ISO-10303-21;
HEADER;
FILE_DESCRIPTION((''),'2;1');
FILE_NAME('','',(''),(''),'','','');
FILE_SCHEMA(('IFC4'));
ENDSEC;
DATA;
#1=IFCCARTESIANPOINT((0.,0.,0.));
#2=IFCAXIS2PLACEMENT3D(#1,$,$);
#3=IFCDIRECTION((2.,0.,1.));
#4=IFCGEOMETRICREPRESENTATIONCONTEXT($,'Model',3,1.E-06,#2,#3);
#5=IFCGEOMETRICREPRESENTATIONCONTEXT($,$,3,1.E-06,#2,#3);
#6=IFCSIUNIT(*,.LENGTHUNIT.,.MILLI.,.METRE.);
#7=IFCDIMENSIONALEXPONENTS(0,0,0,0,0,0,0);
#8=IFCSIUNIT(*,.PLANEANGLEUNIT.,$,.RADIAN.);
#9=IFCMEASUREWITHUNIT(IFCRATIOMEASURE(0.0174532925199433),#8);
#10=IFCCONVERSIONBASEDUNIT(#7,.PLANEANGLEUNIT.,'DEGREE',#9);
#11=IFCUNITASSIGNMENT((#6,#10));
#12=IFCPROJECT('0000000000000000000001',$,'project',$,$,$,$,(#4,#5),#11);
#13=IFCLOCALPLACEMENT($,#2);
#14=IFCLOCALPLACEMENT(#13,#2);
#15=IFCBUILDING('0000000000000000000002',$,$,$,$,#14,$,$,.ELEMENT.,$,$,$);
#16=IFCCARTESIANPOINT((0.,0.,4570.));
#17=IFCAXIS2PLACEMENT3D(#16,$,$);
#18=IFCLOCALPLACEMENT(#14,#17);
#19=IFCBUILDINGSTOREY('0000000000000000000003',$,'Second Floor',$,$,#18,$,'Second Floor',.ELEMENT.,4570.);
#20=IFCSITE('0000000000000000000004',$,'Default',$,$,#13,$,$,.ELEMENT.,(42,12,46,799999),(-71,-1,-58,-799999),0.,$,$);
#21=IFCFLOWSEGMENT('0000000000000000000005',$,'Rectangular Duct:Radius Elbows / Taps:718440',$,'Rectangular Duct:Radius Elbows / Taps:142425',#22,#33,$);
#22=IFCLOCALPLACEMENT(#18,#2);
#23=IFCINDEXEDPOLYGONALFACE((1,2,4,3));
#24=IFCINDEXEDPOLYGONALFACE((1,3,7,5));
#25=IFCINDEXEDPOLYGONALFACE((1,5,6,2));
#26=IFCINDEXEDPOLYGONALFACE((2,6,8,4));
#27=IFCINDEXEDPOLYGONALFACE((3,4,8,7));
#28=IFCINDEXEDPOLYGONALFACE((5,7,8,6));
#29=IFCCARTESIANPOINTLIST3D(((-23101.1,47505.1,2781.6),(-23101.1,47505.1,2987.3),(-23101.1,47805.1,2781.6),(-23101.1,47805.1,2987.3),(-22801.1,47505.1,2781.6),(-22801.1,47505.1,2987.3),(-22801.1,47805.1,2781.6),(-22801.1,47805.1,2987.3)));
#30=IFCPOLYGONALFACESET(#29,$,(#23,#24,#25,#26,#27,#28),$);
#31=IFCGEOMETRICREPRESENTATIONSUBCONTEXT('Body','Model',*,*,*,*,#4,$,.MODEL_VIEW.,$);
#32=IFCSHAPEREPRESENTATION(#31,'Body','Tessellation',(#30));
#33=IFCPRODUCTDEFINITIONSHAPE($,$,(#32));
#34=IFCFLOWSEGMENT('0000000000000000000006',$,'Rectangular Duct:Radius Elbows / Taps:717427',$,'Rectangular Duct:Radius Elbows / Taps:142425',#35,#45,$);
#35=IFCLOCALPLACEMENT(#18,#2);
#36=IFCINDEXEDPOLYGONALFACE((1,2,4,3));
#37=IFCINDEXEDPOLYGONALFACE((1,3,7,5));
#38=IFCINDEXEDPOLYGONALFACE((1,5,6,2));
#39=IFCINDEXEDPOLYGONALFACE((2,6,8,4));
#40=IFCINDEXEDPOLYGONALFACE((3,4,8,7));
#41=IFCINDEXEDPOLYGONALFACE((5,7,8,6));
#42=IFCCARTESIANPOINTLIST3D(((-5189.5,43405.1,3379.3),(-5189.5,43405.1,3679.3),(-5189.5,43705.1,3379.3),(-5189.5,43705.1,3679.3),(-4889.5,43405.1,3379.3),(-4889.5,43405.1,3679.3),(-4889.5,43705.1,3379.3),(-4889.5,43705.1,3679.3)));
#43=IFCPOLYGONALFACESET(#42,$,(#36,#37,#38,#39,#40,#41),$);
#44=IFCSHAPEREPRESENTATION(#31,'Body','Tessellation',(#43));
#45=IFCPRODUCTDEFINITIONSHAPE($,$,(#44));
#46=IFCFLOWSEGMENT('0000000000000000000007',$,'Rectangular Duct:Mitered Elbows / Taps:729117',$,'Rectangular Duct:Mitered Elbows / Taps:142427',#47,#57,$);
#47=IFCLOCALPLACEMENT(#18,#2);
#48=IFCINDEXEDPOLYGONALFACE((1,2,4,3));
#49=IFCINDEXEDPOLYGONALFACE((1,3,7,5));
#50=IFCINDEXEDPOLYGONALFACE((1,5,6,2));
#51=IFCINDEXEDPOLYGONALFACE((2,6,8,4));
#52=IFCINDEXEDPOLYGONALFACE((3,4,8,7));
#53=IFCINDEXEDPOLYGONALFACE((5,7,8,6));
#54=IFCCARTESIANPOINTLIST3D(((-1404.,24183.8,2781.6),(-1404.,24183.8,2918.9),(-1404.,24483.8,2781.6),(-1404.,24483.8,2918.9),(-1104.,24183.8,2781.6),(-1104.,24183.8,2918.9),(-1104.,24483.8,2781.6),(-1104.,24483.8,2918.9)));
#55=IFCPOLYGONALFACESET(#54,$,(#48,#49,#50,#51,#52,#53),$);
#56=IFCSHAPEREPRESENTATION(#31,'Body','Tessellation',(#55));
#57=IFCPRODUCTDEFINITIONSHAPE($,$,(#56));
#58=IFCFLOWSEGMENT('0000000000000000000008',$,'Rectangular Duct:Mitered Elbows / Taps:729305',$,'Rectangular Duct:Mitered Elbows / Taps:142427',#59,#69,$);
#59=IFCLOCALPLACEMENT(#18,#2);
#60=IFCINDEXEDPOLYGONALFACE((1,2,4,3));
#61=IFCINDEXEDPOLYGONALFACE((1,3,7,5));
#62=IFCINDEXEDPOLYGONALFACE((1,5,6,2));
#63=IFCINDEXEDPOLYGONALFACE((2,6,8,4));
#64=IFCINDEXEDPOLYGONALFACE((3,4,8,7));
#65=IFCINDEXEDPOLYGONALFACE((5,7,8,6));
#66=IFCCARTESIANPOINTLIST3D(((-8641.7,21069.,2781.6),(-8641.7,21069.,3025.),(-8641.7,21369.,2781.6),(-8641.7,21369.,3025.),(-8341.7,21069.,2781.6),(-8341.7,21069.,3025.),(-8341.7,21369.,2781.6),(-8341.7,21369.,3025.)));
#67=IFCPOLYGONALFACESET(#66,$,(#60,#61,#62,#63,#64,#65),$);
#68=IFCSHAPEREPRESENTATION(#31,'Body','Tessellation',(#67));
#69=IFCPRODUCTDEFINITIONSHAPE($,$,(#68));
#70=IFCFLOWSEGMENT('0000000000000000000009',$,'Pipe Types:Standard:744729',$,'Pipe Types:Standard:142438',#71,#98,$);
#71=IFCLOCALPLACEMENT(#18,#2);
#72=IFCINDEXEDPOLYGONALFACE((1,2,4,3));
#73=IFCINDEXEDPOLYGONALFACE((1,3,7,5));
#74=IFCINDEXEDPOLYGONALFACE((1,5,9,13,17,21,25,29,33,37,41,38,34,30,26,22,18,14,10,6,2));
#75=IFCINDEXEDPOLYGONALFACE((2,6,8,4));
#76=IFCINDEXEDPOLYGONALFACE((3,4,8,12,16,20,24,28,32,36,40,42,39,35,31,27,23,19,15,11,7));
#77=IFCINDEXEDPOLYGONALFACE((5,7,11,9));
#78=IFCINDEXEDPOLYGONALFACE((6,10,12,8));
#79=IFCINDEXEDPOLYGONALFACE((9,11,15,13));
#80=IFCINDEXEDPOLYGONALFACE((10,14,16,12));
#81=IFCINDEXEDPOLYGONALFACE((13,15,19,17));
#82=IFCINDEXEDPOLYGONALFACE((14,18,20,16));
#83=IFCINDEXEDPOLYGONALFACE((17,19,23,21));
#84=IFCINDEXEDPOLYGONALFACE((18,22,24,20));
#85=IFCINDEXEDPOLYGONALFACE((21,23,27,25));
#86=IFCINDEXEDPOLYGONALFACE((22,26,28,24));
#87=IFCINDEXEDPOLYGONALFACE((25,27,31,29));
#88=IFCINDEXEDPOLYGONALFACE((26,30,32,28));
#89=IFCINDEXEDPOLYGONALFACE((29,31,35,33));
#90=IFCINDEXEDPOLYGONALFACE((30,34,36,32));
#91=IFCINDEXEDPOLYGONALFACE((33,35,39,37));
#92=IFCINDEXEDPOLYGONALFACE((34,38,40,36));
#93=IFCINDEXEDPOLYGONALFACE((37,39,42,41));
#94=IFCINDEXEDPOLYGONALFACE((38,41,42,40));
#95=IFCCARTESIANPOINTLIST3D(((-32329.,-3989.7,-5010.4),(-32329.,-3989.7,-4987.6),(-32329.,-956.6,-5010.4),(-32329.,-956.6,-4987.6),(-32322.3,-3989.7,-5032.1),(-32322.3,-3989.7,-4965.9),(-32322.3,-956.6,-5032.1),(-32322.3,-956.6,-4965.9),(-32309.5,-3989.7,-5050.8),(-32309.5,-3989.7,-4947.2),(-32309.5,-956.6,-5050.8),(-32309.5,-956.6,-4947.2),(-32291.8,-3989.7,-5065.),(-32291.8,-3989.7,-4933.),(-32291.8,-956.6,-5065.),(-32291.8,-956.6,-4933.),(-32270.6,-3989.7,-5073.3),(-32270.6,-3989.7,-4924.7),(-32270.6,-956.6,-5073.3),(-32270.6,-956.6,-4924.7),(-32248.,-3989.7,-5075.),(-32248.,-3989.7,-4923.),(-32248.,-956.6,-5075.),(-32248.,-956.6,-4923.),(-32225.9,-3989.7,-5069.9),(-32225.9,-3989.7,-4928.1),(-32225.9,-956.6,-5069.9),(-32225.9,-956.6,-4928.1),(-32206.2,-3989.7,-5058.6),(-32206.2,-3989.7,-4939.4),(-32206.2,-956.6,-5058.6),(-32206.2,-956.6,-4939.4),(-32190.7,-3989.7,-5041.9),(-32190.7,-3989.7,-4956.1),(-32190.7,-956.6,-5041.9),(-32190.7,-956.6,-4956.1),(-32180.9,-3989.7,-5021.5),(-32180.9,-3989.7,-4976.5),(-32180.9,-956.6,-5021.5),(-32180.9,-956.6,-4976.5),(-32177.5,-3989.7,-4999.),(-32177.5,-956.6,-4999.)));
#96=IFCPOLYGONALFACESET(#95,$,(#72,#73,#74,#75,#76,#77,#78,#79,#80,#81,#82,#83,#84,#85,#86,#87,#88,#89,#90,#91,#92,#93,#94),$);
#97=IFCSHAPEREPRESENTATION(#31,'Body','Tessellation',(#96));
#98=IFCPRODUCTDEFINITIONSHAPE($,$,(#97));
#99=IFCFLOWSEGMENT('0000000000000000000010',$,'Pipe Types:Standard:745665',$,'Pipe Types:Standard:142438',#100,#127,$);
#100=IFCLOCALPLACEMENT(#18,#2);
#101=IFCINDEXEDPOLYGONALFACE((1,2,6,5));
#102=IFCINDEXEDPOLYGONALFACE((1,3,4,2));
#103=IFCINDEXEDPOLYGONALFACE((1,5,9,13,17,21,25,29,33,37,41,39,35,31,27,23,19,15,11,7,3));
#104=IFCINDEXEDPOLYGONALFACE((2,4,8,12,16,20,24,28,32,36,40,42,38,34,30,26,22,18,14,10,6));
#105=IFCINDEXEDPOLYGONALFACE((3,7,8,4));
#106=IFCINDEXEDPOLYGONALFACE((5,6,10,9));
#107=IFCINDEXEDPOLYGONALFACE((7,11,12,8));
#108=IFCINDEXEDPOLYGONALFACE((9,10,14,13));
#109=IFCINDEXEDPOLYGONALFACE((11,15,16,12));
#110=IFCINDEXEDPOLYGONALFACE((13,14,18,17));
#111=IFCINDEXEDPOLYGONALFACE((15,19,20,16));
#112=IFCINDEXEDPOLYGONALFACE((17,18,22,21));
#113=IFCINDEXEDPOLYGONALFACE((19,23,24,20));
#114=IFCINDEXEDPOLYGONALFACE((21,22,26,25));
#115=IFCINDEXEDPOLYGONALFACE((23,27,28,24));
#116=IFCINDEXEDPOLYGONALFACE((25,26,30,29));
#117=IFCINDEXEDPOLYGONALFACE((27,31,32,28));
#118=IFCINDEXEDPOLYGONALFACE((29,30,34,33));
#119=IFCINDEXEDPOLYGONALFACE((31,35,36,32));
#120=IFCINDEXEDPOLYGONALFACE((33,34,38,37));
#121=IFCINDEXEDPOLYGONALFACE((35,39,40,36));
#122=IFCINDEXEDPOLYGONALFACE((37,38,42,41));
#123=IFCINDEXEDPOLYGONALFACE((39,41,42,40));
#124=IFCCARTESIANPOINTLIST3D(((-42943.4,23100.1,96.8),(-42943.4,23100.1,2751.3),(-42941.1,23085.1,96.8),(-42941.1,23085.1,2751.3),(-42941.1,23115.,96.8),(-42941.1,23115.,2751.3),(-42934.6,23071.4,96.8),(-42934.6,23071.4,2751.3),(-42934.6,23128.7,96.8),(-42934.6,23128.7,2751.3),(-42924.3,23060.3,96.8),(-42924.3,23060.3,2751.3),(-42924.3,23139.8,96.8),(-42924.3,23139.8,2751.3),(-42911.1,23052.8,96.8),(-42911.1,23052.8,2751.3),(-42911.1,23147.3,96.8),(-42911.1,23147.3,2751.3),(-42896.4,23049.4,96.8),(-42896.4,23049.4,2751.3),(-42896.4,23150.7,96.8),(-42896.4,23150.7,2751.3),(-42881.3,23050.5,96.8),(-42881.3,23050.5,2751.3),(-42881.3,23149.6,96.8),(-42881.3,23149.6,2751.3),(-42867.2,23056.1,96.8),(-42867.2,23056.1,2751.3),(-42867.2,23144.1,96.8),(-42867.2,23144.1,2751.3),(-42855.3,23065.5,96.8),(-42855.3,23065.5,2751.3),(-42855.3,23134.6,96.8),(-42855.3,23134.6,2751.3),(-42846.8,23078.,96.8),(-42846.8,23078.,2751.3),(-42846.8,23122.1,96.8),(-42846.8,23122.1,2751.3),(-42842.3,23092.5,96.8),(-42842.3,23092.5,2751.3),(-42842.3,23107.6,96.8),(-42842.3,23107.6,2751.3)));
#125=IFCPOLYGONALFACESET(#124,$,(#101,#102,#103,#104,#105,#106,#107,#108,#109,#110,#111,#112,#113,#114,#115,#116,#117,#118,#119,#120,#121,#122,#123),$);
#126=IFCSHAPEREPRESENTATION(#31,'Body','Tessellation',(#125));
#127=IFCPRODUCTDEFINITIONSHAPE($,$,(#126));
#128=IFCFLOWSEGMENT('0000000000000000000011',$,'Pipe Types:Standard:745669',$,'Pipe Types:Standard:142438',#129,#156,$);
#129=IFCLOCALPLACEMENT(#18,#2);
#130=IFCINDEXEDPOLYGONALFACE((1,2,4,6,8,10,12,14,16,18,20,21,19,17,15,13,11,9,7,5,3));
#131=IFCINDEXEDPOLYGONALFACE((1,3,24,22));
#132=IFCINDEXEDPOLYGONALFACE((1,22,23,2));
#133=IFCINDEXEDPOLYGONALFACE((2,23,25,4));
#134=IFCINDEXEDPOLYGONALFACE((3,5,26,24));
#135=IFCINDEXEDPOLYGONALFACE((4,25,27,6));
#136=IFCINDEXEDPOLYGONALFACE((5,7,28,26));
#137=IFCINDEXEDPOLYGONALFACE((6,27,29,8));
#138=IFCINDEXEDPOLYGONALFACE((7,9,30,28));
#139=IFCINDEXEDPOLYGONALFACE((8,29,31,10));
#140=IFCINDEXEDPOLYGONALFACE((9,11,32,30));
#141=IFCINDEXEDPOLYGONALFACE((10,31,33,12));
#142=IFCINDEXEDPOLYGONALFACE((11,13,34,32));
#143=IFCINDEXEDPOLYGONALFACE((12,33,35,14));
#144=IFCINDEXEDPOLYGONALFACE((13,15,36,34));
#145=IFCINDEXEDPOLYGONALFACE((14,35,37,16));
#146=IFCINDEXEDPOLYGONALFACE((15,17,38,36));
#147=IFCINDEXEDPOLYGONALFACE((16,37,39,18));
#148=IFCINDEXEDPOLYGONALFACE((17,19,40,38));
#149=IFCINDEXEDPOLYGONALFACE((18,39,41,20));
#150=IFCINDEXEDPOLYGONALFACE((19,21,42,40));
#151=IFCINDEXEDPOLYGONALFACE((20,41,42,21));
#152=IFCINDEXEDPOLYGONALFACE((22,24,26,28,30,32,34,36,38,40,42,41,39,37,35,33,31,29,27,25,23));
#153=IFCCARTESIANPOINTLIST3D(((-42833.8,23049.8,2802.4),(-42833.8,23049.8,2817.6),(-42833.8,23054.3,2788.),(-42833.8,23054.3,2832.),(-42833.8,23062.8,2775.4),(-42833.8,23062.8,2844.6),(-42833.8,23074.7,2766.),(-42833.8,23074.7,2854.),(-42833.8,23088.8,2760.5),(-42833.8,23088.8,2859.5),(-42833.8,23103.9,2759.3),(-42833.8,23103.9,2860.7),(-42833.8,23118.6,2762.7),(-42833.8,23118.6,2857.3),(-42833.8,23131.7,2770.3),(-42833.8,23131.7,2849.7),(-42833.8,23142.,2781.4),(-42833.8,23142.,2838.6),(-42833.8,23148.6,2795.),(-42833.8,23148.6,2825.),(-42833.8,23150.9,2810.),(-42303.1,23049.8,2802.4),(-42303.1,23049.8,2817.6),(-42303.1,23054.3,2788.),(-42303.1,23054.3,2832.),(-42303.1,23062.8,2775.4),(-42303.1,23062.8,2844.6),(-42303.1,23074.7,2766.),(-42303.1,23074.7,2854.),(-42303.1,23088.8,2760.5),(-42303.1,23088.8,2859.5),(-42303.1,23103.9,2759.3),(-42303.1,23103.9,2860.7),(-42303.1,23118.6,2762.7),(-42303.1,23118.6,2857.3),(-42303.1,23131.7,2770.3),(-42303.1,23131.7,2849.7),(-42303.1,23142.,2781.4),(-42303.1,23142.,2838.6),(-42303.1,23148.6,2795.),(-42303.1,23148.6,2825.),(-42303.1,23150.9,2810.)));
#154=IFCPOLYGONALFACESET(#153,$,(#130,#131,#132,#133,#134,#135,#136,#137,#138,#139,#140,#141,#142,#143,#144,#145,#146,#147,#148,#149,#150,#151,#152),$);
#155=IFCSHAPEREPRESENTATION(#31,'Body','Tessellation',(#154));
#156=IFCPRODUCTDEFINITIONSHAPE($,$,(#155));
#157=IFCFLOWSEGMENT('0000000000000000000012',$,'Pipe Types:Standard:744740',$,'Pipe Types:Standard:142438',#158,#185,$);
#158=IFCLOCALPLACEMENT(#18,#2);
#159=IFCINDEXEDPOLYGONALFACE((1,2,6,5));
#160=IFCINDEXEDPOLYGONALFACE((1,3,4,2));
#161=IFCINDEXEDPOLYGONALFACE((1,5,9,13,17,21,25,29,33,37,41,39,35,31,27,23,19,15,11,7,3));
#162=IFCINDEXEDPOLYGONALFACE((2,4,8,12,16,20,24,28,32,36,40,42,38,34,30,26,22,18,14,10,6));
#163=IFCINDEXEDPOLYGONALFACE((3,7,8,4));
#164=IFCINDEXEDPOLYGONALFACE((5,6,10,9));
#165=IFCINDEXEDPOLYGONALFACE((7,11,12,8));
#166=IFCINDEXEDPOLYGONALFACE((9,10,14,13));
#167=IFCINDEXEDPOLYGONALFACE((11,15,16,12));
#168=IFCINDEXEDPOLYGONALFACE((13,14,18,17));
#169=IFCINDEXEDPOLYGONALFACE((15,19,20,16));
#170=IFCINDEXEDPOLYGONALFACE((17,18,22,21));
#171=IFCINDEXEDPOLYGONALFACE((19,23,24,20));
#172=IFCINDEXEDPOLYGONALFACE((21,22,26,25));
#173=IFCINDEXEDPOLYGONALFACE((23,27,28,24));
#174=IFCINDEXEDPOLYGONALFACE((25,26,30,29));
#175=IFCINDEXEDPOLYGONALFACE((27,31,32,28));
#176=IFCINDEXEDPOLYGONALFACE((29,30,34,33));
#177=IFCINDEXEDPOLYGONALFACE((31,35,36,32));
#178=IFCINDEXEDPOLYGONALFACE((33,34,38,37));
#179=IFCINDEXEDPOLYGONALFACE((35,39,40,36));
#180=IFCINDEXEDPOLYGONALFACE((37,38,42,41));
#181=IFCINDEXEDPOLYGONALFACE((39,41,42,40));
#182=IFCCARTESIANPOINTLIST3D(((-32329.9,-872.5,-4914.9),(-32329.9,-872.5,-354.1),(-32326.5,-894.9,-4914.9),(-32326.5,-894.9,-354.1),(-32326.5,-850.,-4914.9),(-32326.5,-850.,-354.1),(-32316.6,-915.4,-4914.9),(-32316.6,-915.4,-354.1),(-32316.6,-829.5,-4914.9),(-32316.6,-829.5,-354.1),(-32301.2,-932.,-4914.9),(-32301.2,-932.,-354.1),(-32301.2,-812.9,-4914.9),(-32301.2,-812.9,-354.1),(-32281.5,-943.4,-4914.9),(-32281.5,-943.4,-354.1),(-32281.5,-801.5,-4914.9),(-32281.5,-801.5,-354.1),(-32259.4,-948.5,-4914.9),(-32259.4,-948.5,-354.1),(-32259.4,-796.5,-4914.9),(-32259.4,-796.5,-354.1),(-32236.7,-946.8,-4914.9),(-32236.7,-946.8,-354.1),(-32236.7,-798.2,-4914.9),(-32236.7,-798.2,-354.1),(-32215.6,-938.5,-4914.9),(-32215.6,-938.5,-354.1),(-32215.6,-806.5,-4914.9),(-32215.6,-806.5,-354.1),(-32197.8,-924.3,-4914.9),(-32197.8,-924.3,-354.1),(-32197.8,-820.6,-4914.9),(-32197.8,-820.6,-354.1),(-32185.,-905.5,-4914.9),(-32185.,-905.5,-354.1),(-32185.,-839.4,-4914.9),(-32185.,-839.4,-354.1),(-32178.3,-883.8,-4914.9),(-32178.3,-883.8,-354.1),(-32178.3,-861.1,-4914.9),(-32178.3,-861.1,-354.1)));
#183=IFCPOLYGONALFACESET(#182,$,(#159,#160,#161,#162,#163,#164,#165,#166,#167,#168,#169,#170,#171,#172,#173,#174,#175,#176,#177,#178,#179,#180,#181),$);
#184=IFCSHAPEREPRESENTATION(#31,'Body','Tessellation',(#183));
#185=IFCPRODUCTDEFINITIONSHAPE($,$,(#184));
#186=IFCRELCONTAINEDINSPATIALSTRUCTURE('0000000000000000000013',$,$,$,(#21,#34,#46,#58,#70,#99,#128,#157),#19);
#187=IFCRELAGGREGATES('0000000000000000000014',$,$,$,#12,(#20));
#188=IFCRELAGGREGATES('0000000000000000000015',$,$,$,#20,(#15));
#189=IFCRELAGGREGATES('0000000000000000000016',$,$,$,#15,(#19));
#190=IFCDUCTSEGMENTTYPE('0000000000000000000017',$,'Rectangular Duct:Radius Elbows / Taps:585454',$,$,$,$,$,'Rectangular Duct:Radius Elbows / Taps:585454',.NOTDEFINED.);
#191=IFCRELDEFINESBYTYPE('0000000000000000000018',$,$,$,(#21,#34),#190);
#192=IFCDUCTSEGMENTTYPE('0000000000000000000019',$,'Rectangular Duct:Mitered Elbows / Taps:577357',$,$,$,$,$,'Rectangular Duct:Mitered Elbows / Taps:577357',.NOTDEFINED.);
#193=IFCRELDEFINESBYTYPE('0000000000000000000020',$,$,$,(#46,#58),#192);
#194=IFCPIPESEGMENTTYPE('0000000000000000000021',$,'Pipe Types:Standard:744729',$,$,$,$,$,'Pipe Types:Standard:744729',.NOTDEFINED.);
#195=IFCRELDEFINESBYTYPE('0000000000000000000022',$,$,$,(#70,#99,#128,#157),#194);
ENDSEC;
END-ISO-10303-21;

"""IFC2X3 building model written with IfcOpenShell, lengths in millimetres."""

from ifc_helpers import new_model, entity, si_unit, converted_unit, direction, frame, frame_2d, origin, origin_2d_with_axis, place, context, subcontext, project, spatial, rectangle, circle, extrude, type_object, element, save


model = new_model("IFC2X3")

# Units and contexts
model_context = context("Model", 3, precision=1e-06, world=origin(), true_north=direction((2.0, 0.0, 1.0)))
context_of_model = context(None, 3, precision=1e-06, world=origin(), true_north=direction((2.0, 0.0, 1.0)))
body_context = subcontext(model_context, "Body", "Model", "MODEL_VIEW")
ifc_project = project(units=[si_unit("LENGTHUNIT", "METRE", prefix="MILLI"), converted_unit("PLANEANGLEUNIT", "DEGREE", entity("IfcRatioMeasure", 0.0174532925199433), si_unit("PLANEANGLEUNIT", "RADIAN"), dimensions=[0, 0, 0, 0, 0, 0, 0])], contexts=[model_context, context_of_model])

# Site, building, storey
site_placement = place(None, origin())
site = spatial("IfcSite", under=ifc_project, at=site_placement, Name="Default", CompositionType="ELEMENT", RefLatitude=(42, 12, 46, 799999), RefLongitude=(-71, -1, -58, -799999), RefElevation=0.0)
building_placement = place(site_placement, origin())
building = spatial("IfcBuilding", under=site, at=building_placement, CompositionType="ELEMENT")
storey_placement = place(building_placement, frame((0.0, 0.0, 4570.0)))
storey = spatial("IfcBuildingStorey", under=building, at=storey_placement, Name="Second Floor", LongName="Second Floor", CompositionType="ELEMENT", Elevation=4570.0)

# Flow segments
duct_segment_type_1 = type_object("IfcDuctSegmentType", Name="Rectangular Duct:Radius Elbows / Taps:585454", ElementType="Rectangular Duct:Radius Elbows / Taps:585454", PredefinedType="NOTDEFINED")
flow_segment_1_placement = place(storey_placement, origin())
element("IfcFlowSegment", 1, at=flow_segment_1_placement, inside=storey, type_object=duct_segment_type_1, Name="Rectangular Duct:Radius Elbows / Taps:718440", ObjectType="Rectangular Duct:Radius Elbows / Taps:142425", context=body_context, shape_type="SweptSolid", body=[
    extrude(rectangle(XDim=300.0, YDim=300.0, at=origin_2d_with_axis()), frame((-22951.1, 47655.1, 2781.6), z_axis=(0.0, 0.0, 1.0), x_axis=(-1.0, 0.0, 0.0)), (0.0, 0.0, 1.0), 205.7),
])
flow_segment_2_placement = place(storey_placement, origin())
element("IfcFlowSegment", 2, at=flow_segment_2_placement, inside=storey, type_object=duct_segment_type_1, Name="Rectangular Duct:Radius Elbows / Taps:717427", ObjectType="Rectangular Duct:Radius Elbows / Taps:142425", context=body_context, shape_type="SweptSolid", body=[
    extrude(rectangle(XDim=300.0, YDim=300.0, at=frame_2d((0.0, 0.0), x_axis=(1.0, 0.0))), frame((-5039.5, 43555.1, 3379.3), z_axis=(0.0, 0.0, 1.0), x_axis=(-1.0, 0.0, 0.0)), (0.0, 0.0, 1.0), 300.0),
])
duct_segment_type_2 = type_object("IfcDuctSegmentType", Name="Rectangular Duct:Mitered Elbows / Taps:577357", ElementType="Rectangular Duct:Mitered Elbows / Taps:577357", PredefinedType="NOTDEFINED")
flow_segment_3_placement = place(storey_placement, origin())
element("IfcFlowSegment", 3, at=flow_segment_3_placement, inside=storey, type_object=duct_segment_type_2, Name="Rectangular Duct:Mitered Elbows / Taps:729117", ObjectType="Rectangular Duct:Mitered Elbows / Taps:142427", context=body_context, shape_type="SweptSolid", body=[
    extrude(rectangle(XDim=300.0, YDim=300.0, at=origin_2d_with_axis()), frame((-1254.0, 24333.8, 2781.6), z_axis=(0.0, 0.0, 1.0), x_axis=(0.0, 1.0, 0.0)), (0.0, 0.0, 1.0), 137.3),
])
flow_segment_4_placement = place(storey_placement, origin())
element("IfcFlowSegment", 4, at=flow_segment_4_placement, inside=storey, type_object=duct_segment_type_2, Name="Rectangular Duct:Mitered Elbows / Taps:729305", ObjectType="Rectangular Duct:Mitered Elbows / Taps:142427", context=body_context, shape_type="SweptSolid", body=[
    extrude(rectangle(XDim=300.0, YDim=300.0, at=frame_2d((0.0, 0.0), x_axis=(1.0, 0.0))), frame((-8491.7, 21219.0, 2781.6), z_axis=(0.0, 0.0, 1.0), x_axis=(-1.0, 0.0, 0.0)), (0.0, 0.0, 1.0), 243.4),
])
pipe_segment_type = type_object("IfcPipeSegmentType", Name="Pipe Types:Standard:744729", ElementType="Pipe Types:Standard:744729", PredefinedType="NOTDEFINED")
flow_segment_5_placement = place(storey_placement, origin())
element("IfcFlowSegment", 5, at=flow_segment_5_placement, inside=storey, type_object=pipe_segment_type, Name="Pipe Types:Standard:744729", ObjectType="Pipe Types:Standard:142438", context=body_context, shape_type="SweptSolid", body=[
    extrude(circle(Radius=76.2, at=frame_2d((0.0, 0.0), x_axis=(1.0, 0.0))), frame((-32253.7, -3989.7, -4999.0), z_axis=(0.0, 1.0, 0.0), x_axis=(1.0, 0.0, 0.0)), (0.0, 0.0, 1.0), 3033.1),
])
flow_segment_6_placement = place(storey_placement, origin())
element("IfcFlowSegment", 6, at=flow_segment_6_placement, inside=storey, type_object=pipe_segment_type, Name="Pipe Types:Standard:745665", ObjectType="Pipe Types:Standard:142438", context=body_context, shape_type="SweptSolid", body=[
    extrude(circle(Radius=50.8, at=origin_2d_with_axis()), frame((-42892.6, 23100.1, 96.8), z_axis=(0.0, 0.0, 1.0), x_axis=(-1.0, 0.0, 0.0)), (0.0, 0.0, 1.0), 2654.4),
])
flow_segment_7_placement = place(storey_placement, origin())
element("IfcFlowSegment", 7, at=flow_segment_7_placement, inside=storey, type_object=pipe_segment_type, Name="Pipe Types:Standard:745669", ObjectType="Pipe Types:Standard:142438", context=body_context, shape_type="SweptSolid", body=[
    extrude(circle(Radius=50.8, at=frame_2d((0.0, 0.0), x_axis=(1.0, 0.0))), frame((-42833.8, 23100.1, 2810.0), z_axis=(1.0, 0.0, 0.0), x_axis=(0.0, 1.0, 0.0)), (0.0, 0.0, 1.0), 530.8),
])
flow_segment_8_placement = place(storey_placement, origin())
element("IfcFlowSegment", 8, at=flow_segment_8_placement, inside=storey, type_object=pipe_segment_type, Name="Pipe Types:Standard:744740", ObjectType="Pipe Types:Standard:142438", context=body_context, shape_type="SweptSolid", body=[
    extrude(circle(Radius=76.2, at=origin_2d_with_axis()), frame((-32253.7, -872.5, -4914.9), z_axis=(0.0, 0.0, 1.0), x_axis=(-1.0, 0.0, 0.0)), (0.0, 0.0, 1.0), 4560.7),
])

save(model, "model.ifc")
